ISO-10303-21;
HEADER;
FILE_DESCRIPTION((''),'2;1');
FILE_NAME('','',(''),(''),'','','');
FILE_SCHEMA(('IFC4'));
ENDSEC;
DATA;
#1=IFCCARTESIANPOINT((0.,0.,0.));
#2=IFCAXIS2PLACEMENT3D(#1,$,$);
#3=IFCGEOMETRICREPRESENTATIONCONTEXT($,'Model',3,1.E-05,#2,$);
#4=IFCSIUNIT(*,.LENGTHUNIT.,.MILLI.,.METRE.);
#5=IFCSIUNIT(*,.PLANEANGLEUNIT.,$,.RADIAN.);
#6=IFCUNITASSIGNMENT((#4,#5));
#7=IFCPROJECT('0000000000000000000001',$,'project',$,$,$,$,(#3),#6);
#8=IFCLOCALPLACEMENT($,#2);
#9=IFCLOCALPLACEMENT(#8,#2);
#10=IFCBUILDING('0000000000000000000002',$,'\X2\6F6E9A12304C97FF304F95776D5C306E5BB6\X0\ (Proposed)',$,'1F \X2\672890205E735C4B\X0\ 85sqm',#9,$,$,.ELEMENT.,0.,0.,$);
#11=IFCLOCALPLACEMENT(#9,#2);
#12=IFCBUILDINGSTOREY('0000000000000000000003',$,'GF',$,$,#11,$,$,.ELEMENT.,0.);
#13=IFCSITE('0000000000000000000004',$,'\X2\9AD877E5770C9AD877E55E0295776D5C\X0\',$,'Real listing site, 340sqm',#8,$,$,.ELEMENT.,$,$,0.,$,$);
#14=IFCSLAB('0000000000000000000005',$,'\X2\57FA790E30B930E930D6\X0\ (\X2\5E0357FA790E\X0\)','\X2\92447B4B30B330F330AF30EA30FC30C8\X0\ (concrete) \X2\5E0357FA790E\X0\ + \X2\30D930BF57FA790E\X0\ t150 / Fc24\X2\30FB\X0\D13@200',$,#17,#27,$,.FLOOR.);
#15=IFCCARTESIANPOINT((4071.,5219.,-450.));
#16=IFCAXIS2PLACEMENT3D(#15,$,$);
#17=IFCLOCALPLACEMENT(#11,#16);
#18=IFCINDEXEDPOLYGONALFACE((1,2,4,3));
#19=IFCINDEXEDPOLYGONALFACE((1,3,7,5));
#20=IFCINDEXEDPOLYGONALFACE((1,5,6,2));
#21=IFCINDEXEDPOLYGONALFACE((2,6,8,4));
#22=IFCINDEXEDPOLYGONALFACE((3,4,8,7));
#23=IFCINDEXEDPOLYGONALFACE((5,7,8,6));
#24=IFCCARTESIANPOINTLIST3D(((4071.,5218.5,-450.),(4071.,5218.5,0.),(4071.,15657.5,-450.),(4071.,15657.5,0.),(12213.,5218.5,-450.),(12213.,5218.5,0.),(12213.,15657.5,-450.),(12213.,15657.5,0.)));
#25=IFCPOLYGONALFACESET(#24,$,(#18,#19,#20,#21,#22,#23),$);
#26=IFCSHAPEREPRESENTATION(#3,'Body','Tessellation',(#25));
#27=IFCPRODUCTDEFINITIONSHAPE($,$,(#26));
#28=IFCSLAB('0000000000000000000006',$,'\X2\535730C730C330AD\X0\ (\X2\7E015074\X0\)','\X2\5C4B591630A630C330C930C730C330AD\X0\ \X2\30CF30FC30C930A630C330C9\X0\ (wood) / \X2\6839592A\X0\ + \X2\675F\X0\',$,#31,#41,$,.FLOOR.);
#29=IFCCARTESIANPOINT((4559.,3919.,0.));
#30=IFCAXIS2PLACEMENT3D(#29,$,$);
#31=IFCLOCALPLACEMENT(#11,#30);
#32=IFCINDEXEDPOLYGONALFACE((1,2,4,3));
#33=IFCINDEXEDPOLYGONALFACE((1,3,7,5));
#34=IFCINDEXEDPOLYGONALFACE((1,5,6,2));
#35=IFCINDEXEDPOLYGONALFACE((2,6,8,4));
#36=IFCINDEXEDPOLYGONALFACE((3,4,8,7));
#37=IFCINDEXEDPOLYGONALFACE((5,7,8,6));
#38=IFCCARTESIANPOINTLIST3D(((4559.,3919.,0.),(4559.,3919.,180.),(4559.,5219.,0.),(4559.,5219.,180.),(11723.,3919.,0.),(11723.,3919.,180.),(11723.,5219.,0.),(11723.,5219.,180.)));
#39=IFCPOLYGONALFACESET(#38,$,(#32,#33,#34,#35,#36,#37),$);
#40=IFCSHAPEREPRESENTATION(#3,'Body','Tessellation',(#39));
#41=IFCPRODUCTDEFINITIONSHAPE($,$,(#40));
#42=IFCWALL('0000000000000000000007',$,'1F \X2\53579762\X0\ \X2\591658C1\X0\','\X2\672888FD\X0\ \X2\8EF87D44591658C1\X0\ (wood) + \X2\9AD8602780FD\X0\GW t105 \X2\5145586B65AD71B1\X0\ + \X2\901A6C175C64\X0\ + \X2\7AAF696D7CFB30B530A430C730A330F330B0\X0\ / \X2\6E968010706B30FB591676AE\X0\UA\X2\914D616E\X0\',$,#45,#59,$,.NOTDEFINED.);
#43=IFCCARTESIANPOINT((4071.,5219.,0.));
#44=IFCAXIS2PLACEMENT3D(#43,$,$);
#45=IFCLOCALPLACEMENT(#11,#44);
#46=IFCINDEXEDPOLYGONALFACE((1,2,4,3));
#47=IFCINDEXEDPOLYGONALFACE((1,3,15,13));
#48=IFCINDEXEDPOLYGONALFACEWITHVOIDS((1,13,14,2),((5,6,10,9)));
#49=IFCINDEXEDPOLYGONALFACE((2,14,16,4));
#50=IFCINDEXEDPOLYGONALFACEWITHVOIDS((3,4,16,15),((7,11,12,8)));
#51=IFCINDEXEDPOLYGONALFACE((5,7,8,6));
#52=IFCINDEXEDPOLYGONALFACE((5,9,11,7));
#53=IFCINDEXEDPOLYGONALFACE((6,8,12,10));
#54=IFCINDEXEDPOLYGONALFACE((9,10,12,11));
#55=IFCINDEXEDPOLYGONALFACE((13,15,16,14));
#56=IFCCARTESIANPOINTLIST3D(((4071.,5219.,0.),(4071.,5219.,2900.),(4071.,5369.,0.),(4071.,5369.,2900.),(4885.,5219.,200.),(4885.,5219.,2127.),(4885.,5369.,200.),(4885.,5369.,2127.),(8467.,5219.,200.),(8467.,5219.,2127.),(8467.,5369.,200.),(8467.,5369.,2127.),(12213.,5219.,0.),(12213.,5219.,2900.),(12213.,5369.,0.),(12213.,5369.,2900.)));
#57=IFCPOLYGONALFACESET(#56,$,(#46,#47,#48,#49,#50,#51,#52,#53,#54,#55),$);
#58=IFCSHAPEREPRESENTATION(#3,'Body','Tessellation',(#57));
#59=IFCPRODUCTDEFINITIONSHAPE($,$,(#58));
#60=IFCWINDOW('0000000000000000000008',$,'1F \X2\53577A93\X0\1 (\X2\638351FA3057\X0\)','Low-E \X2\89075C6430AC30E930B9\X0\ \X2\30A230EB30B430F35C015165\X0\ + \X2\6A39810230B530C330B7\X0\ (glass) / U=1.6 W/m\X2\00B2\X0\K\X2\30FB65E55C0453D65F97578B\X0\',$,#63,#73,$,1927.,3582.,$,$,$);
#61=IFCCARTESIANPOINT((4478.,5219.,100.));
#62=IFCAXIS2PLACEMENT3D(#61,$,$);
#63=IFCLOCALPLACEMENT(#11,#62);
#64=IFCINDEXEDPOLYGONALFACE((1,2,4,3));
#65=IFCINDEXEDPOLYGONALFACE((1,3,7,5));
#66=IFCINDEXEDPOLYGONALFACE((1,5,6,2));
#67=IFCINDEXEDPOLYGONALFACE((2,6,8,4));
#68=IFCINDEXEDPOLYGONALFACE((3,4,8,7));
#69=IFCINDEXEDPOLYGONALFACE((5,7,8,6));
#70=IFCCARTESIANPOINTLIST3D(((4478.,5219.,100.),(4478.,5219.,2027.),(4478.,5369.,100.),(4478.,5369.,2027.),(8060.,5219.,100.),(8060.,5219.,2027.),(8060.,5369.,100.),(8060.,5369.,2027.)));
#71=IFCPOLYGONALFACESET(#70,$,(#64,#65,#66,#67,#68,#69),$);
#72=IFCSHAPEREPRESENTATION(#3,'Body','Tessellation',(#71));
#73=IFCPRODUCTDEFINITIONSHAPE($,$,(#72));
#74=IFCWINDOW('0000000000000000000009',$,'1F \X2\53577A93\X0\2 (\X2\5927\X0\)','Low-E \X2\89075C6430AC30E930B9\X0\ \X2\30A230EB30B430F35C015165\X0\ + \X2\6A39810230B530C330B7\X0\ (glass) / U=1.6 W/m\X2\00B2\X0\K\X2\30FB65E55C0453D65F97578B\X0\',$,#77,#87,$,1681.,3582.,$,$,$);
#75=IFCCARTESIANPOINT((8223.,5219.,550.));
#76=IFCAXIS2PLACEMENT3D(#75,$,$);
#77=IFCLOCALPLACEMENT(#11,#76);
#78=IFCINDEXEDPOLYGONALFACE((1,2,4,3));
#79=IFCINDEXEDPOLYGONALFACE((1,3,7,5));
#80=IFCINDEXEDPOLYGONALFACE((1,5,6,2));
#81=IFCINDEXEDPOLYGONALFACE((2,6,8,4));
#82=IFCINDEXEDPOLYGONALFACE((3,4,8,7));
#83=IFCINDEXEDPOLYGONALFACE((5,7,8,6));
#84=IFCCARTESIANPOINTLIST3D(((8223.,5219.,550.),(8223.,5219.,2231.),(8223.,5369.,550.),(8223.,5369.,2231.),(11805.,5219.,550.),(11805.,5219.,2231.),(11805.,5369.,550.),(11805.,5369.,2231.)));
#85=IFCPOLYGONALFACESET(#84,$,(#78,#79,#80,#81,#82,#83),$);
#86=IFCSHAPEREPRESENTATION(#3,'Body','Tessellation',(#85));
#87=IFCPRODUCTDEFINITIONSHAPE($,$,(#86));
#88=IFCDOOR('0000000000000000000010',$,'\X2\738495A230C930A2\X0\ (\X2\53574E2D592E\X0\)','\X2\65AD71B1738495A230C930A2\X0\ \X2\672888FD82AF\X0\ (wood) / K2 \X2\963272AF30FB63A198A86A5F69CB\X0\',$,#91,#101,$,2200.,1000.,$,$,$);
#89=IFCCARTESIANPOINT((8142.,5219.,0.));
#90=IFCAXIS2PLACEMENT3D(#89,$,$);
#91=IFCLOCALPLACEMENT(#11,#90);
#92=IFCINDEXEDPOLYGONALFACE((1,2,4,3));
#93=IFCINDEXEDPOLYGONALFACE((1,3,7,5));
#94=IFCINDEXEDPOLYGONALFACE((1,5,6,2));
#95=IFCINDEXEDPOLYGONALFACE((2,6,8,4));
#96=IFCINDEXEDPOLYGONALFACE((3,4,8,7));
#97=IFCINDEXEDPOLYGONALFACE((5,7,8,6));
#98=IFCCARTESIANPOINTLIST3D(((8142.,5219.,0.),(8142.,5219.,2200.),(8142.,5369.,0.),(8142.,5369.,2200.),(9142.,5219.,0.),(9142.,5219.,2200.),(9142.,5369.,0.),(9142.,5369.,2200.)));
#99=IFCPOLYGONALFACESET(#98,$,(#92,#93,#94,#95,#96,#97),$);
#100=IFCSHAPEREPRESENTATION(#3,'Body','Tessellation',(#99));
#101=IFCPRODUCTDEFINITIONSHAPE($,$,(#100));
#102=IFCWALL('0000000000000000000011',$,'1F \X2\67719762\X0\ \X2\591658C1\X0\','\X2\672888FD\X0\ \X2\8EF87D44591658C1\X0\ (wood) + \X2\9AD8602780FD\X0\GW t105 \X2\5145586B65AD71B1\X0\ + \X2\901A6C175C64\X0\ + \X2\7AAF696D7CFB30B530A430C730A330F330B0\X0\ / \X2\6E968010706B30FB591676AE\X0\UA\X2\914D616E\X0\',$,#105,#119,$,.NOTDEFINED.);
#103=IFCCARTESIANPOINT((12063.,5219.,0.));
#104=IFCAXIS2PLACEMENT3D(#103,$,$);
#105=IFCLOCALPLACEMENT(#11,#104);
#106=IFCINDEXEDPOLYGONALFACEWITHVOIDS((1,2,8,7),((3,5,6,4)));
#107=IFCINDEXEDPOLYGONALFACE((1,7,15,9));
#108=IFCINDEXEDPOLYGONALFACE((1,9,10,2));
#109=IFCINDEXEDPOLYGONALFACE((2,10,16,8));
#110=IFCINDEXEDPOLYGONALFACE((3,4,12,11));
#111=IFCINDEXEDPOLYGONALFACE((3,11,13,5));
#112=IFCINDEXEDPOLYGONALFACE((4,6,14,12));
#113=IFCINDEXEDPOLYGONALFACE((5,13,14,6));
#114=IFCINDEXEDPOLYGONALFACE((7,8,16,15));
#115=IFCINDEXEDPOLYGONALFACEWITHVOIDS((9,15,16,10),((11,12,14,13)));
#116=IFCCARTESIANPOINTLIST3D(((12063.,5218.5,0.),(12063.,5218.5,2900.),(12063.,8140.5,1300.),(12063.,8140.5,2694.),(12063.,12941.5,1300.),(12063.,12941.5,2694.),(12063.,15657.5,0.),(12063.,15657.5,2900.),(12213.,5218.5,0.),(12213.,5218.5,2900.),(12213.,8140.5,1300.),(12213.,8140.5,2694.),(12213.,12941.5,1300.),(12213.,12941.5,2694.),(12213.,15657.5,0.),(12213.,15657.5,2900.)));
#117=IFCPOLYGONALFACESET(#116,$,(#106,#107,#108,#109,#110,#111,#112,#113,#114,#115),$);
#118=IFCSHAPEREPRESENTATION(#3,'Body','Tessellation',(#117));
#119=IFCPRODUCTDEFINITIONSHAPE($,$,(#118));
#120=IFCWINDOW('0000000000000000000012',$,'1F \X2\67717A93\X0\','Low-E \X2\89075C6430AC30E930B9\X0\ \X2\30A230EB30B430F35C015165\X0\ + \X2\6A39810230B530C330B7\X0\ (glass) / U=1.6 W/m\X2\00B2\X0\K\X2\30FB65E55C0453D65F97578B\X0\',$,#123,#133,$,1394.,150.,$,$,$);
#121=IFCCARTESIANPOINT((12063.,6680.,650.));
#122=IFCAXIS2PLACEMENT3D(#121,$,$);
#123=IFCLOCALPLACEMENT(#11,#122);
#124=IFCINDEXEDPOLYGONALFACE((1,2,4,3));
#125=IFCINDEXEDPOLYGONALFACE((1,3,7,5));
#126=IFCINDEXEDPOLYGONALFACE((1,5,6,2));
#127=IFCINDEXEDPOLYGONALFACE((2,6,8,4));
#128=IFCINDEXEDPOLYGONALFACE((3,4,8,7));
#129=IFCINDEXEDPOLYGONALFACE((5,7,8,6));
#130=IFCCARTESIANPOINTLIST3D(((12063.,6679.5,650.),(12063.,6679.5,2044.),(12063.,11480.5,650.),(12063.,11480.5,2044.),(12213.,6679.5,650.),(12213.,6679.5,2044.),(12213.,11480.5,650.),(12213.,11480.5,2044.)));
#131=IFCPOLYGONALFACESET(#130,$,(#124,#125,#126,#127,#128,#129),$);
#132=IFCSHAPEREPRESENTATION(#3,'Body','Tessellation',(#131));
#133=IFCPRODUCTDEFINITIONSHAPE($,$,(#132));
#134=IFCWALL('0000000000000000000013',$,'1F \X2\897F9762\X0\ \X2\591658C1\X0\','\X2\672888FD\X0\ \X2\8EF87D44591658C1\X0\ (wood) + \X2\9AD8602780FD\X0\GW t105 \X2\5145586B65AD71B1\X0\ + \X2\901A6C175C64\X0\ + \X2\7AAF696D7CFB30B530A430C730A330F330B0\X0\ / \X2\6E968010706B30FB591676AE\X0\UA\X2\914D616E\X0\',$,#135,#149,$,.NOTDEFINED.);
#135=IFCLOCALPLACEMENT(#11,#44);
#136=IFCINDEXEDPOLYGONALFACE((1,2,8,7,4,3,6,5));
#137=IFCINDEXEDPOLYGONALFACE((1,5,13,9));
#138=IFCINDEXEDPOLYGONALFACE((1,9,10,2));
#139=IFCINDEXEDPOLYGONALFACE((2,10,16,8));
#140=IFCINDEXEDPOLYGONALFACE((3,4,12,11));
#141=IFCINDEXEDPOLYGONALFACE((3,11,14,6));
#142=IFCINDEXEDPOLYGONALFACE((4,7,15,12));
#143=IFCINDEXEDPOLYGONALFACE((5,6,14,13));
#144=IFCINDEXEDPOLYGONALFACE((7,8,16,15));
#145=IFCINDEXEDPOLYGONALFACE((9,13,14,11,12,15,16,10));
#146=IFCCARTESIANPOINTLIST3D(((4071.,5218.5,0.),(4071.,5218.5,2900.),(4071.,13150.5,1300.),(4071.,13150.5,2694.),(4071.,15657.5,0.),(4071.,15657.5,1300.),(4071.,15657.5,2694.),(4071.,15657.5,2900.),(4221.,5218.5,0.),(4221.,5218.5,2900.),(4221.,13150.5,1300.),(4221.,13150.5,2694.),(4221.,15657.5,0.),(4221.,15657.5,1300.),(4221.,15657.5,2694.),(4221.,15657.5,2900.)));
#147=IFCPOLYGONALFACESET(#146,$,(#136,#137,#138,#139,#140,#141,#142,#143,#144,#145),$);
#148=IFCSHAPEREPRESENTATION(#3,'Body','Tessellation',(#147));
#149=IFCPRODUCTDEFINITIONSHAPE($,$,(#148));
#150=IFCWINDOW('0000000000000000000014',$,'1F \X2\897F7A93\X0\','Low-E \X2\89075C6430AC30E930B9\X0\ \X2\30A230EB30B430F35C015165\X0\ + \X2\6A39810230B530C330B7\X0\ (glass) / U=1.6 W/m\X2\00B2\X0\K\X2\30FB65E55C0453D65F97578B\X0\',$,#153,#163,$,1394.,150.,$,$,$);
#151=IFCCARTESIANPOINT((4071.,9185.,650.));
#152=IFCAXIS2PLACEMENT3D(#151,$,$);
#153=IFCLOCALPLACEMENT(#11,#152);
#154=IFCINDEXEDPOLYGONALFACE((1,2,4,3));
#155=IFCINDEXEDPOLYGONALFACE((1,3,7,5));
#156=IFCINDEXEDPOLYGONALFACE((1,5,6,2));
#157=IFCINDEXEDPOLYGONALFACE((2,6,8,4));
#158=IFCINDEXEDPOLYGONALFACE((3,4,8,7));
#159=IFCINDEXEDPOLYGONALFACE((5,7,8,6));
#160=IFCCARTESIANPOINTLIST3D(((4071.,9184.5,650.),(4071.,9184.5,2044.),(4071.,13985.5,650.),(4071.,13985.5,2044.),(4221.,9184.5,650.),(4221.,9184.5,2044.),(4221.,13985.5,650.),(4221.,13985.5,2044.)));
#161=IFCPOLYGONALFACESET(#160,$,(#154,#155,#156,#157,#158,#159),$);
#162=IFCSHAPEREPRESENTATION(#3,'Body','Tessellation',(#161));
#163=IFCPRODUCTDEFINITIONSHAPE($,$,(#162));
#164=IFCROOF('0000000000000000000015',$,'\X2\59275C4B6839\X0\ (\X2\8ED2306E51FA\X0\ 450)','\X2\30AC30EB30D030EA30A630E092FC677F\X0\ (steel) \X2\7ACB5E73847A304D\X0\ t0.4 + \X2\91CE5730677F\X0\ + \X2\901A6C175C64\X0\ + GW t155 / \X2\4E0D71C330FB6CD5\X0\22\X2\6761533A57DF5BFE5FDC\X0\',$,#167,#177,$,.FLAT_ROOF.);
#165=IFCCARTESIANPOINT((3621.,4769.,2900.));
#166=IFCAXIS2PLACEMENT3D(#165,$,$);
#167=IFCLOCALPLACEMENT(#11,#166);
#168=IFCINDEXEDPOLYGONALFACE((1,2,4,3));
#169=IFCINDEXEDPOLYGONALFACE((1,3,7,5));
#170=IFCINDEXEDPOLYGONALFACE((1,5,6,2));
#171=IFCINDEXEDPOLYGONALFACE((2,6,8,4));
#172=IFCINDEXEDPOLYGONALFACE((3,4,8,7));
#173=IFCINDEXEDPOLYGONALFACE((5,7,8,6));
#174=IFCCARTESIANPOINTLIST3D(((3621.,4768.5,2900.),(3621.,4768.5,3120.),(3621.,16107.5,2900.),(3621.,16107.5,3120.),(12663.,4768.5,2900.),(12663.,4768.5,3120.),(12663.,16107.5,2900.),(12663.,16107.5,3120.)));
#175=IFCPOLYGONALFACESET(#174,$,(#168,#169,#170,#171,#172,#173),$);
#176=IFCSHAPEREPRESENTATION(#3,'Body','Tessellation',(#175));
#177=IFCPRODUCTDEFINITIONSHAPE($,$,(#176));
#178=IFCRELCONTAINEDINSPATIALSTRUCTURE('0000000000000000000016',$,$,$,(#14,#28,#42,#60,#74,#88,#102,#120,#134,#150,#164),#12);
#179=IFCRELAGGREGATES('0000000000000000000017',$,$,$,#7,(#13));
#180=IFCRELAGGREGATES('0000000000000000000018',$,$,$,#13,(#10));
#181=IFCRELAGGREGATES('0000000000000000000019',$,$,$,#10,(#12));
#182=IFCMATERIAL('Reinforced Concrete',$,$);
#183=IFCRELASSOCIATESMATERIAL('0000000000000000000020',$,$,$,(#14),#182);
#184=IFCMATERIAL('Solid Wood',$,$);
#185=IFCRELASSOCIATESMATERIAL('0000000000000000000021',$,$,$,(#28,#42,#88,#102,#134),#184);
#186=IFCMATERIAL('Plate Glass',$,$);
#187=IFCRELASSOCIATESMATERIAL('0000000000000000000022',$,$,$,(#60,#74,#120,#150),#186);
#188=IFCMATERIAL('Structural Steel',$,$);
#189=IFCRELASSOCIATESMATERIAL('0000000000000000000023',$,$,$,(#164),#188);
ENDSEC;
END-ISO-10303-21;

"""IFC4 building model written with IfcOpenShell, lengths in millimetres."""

from ifc_helpers import new_model, si_unit, frame, frame_2d, origin, place, context, project, spatial, rectangle, extrude, material, element, fill, save


model = new_model("IFC4")

# Units and contexts
model_context = context("Model", 3, precision=1e-05, world=origin())
ifc_project = project(units=[si_unit("LENGTHUNIT", "METRE", prefix="MILLI"), si_unit("PLANEANGLEUNIT", "RADIAN")], contexts=[model_context])

# Site, building, storey
site_placement = place(None, origin())
site = spatial("IfcSite", under=ifc_project, at=site_placement, Name="高知県高知市長浜", ObjectType="Real listing site, 340sqm", CompositionType="ELEMENT", RefElevation=0.0)
building_placement = place(site_placement, origin())
building = spatial("IfcBuilding", under=site, at=building_placement, Name="潮騒が響く長浜の家 (Proposed)", ObjectType="1F 木造平屋 85sqm", CompositionType="ELEMENT", ElevationOfRefHeight=0.0, ElevationOfTerrain=0.0)
storey_placement = place(building_placement, origin())
storey = spatial("IfcBuildingStorey", under=building, at=storey_placement, Name="GF", CompositionType="ELEMENT", Elevation=0.0)

# Slabs
ifc_material_1 = material(Name="Reinforced Concrete")
slab_1_placement = place(storey_placement, frame((4071.0, 5219.0, -450.0)))
element("IfcSlab", 1, at=slab_1_placement, inside=storey, material=ifc_material_1, Name="基礎スラブ (布基礎)", Description="鉄筋コンクリート (concrete) 布基礎 + ベタ基礎 t150 / Fc24・D13@200", PredefinedType="FLOOR", context=model_context, shape_type="SweptSolid", body=[
    extrude(rectangle(XDim=8142.0, YDim=10439.0, at=frame_2d((4071.0, 5219.0))), frame((4071.0, 5219.0, -450.0)), (0.0, 0.0, 1.0), 450.0),
])
ifc_material_2 = material(Name="Solid Wood")
slab_2_placement = place(storey_placement, frame((4559.0, 3919.0, 0.0)))
element("IfcSlab", 2, at=slab_2_placement, inside=storey, material=ifc_material_2, Name="南デッキ (縁側)", Description="屋外ウッドデッキ ハードウッド (wood) / 根太 + 束", PredefinedType="FLOOR", context=model_context, shape_type="SweptSolid", body=[
    extrude(rectangle(XDim=7164.0, YDim=1300.0, at=frame_2d((3582.0, 650.0))), frame((4559.0, 3919.0, 0.0)), (0.0, 0.0, 1.0), 180.0),
])

# Wall, openings, windows, door
wall_1_placement = place(storey_placement, frame((4071.0, 5219.0, 0.0)))
wall_1 = element("IfcWall", 3, at=wall_1_placement, inside=storey, material=ifc_material_2, Name="1F 南面 外壁", Description="木製 軸組外壁 (wood) + 高性能GW t105 充填断熱 + 通気層 + 窯業系サイディング / 準耐火・外皮UA配慮", PredefinedType="NOTDEFINED", context=model_context, shape_type="SweptSolid", body=[
    extrude(rectangle(XDim=8142.0, YDim=150.0, at=frame_2d((4071.0, 75.0))), frame((4071.0, 5219.0, 0.0)), (0.0, 0.0, 1.0), 2900.0),
])
opening_1_placement = place(storey_placement, frame((4478.0, 5219.0, 100.0)))
opening_1 = element("IfcOpeningElement", 4, at=opening_1_placement, cuts=wall_1, PredefinedType="NOTDEFINED", context=model_context, shape_type="SweptSolid", body=[
    extrude(rectangle(XDim=3582.0, YDim=150.0, at=frame_2d((1791.0, 75.0))), frame((4478.0, 5219.0, 100.0)), (0.0, 0.0, 1.0), 1927.0),
])
opening_2_placement = place(storey_placement, frame((8223.0, 5219.0, 550.0)))
opening_2 = element("IfcOpeningElement", 5, at=opening_2_placement, cuts=wall_1, PredefinedType="NOTDEFINED", context=model_context, shape_type="SweptSolid", body=[
    extrude(rectangle(XDim=3582.0, YDim=150.0, at=frame_2d((1791.0, 75.0))), frame((8223.0, 5219.0, 550.0)), (0.0, 0.0, 1.0), 1681.0),
])
opening_3_placement = place(storey_placement, frame((8142.0, 5219.0, 0.0)))
opening_3 = element("IfcOpeningElement", 6, at=opening_3_placement, cuts=wall_1, PredefinedType="NOTDEFINED", context=model_context, shape_type="SweptSolid", body=[
    extrude(rectangle(XDim=1000.0, YDim=150.0, at=frame_2d((500.0, 75.0))), frame((8142.0, 5219.0, 0.0)), (0.0, 0.0, 1.0), 2200.0),
])
ifc_material_3 = material(Name="Plate Glass")
window_1_placement = place(storey_placement, frame((4478.0, 5219.0, 100.0)))
window_1 = element("IfcWindow", 7, at=window_1_placement, inside=storey, material=ifc_material_3, Name="1F 南窓1 (掃出し)", Description="Low-E 複層ガラス アルゴン封入 + 樹脂サッシ (glass) / U=1.6 W/m²K・日射取得型", OverallHeight=1927.0, OverallWidth=3582.0, context=model_context, shape_type="SweptSolid", body=[
    extrude(rectangle(XDim=3582.0, YDim=150.0, at=frame_2d((1791.0, 75.0))), frame((4478.0, 5219.0, 100.0)), (0.0, 0.0, 1.0), 1927.0),
])
fill(opening_1, window_1)
window_2_placement = place(storey_placement, frame((8223.0, 5219.0, 550.0)))
window_2 = element("IfcWindow", 8, at=window_2_placement, inside=storey, material=ifc_material_3, Name="1F 南窓2 (大)", Description="Low-E 複層ガラス アルゴン封入 + 樹脂サッシ (glass) / U=1.6 W/m²K・日射取得型", OverallHeight=1681.0, OverallWidth=3582.0, context=model_context, shape_type="SweptSolid", body=[
    extrude(rectangle(XDim=3582.0, YDim=150.0, at=frame_2d((1791.0, 75.0))), frame((8223.0, 5219.0, 550.0)), (0.0, 0.0, 1.0), 1681.0),
])
fill(opening_2, window_2)
door_placement = place(storey_placement, frame((8142.0, 5219.0, 0.0)))
door = element("IfcDoor", 9, at=door_placement, inside=storey, material=ifc_material_2, Name="玄関ドア (南中央)", Description="断熱玄関ドア 木製芯 (wood) / K2 防犯・採風機構", OverallHeight=2200.0, OverallWidth=1000.0, context=model_context, shape_type="SweptSolid", body=[
    extrude(rectangle(XDim=1000.0, YDim=150.0, at=frame_2d((500.0, 75.0))), frame((8142.0, 5219.0, 0.0)), (0.0, 0.0, 1.0), 2200.0),
])
fill(opening_3, door)

# Walls, openings, windows
wall_2_placement = place(storey_placement, frame((12063.0, 5219.0, 0.0)))
wall_2 = element("IfcWall", 10, at=wall_2_placement, inside=storey, material=ifc_material_2, Name="1F 東面 外壁", Description="木製 軸組外壁 (wood) + 高性能GW t105 充填断熱 + 通気層 + 窯業系サイディング / 準耐火・外皮UA配慮", PredefinedType="NOTDEFINED", context=model_context, shape_type="SweptSolid", body=[
    extrude(rectangle(XDim=150.0, YDim=10439.0, at=frame_2d((75.0, 5219.0))), frame((12063.0, 5219.0, 0.0)), (0.0, 0.0, 1.0), 2900.0),
])
opening_4_placement = place(storey_placement, frame((12063.0, 6680.0, 650.0)))
opening_4 = element("IfcOpeningElement", 11, at=opening_4_placement, cuts=wall_2, PredefinedType="NOTDEFINED", context=model_context, shape_type="SweptSolid", body=[
    extrude(rectangle(XDim=150.0, YDim=4801.0, at=frame_2d((75.0, 2400.0))), frame((12063.0, 6680.0, 650.0)), (0.0, 0.0, 1.0), 1394.0),
])
window_3_placement = place(storey_placement, frame((12063.0, 6680.0, 650.0)))
window_3 = element("IfcWindow", 12, at=window_3_placement, inside=storey, material=ifc_material_3, Name="1F 東窓", Description="Low-E 複層ガラス アルゴン封入 + 樹脂サッシ (glass) / U=1.6 W/m²K・日射取得型", OverallHeight=1394.0, OverallWidth=150.0, context=model_context, shape_type="SweptSolid", body=[
    extrude(rectangle(XDim=150.0, YDim=4801.0, at=frame_2d((75.0, 2400.0))), frame((12063.0, 6680.0, 650.0)), (0.0, 0.0, 1.0), 1394.0),
])
fill(opening_4, window_3)
wall_3_placement = place(storey_placement, frame((4071.0, 5219.0, 0.0)))
wall_3 = element("IfcWall", 13, at=wall_3_placement, inside=storey, material=ifc_material_2, Name="1F 西面 外壁", Description="木製 軸組外壁 (wood) + 高性能GW t105 充填断熱 + 通気層 + 窯業系サイディング / 準耐火・外皮UA配慮", PredefinedType="NOTDEFINED", context=model_context, shape_type="SweptSolid", body=[
    extrude(rectangle(XDim=150.0, YDim=10439.0, at=frame_2d((75.0, 5219.0))), frame((4071.0, 5219.0, 0.0)), (0.0, 0.0, 1.0), 2900.0),
])
opening_5_placement = place(storey_placement, frame((4071.0, 9185.0, 650.0)))
opening_5 = element("IfcOpeningElement", 14, at=opening_5_placement, cuts=wall_3, PredefinedType="NOTDEFINED", context=model_context, shape_type="SweptSolid", body=[
    extrude(rectangle(XDim=150.0, YDim=4801.0, at=frame_2d((75.0, 2400.0))), frame((4071.0, 9185.0, 650.0)), (0.0, 0.0, 1.0), 1394.0),
])
window_4_placement = place(storey_placement, frame((4071.0, 9185.0, 650.0)))
window_4 = element("IfcWindow", 15, at=window_4_placement, inside=storey, material=ifc_material_3, Name="1F 西窓", Description="Low-E 複層ガラス アルゴン封入 + 樹脂サッシ (glass) / U=1.6 W/m²K・日射取得型", OverallHeight=1394.0, OverallWidth=150.0, context=model_context, shape_type="SweptSolid", body=[
    extrude(rectangle(XDim=150.0, YDim=4801.0, at=frame_2d((75.0, 2400.0))), frame((4071.0, 9185.0, 650.0)), (0.0, 0.0, 1.0), 1394.0),
])
fill(opening_5, window_4)

# Roof
ifc_material_4 = material(Name="Structural Steel")
roof_placement = place(storey_placement, frame((3621.0, 4769.0, 2900.0)))
element("IfcRoof", 16, at=roof_placement, inside=storey, material=ifc_material_4, Name="大屋根 (軒の出 450)", Description="ガルバリウム鋼板 (steel) 立平葺き t0.4 + 野地板 + 通気層 + GW t155 / 不燃・法22条区域対応", PredefinedType="FLAT_ROOF", context=model_context, shape_type="SweptSolid", body=[
    extrude(rectangle(XDim=9042.0, YDim=11339.0, at=frame_2d((4521.0, 5669.0))), frame((3621.0, 4769.0, 2900.0)), (0.0, 0.0, 1.0), 220.0),
])

save(model, "model.ifc")
